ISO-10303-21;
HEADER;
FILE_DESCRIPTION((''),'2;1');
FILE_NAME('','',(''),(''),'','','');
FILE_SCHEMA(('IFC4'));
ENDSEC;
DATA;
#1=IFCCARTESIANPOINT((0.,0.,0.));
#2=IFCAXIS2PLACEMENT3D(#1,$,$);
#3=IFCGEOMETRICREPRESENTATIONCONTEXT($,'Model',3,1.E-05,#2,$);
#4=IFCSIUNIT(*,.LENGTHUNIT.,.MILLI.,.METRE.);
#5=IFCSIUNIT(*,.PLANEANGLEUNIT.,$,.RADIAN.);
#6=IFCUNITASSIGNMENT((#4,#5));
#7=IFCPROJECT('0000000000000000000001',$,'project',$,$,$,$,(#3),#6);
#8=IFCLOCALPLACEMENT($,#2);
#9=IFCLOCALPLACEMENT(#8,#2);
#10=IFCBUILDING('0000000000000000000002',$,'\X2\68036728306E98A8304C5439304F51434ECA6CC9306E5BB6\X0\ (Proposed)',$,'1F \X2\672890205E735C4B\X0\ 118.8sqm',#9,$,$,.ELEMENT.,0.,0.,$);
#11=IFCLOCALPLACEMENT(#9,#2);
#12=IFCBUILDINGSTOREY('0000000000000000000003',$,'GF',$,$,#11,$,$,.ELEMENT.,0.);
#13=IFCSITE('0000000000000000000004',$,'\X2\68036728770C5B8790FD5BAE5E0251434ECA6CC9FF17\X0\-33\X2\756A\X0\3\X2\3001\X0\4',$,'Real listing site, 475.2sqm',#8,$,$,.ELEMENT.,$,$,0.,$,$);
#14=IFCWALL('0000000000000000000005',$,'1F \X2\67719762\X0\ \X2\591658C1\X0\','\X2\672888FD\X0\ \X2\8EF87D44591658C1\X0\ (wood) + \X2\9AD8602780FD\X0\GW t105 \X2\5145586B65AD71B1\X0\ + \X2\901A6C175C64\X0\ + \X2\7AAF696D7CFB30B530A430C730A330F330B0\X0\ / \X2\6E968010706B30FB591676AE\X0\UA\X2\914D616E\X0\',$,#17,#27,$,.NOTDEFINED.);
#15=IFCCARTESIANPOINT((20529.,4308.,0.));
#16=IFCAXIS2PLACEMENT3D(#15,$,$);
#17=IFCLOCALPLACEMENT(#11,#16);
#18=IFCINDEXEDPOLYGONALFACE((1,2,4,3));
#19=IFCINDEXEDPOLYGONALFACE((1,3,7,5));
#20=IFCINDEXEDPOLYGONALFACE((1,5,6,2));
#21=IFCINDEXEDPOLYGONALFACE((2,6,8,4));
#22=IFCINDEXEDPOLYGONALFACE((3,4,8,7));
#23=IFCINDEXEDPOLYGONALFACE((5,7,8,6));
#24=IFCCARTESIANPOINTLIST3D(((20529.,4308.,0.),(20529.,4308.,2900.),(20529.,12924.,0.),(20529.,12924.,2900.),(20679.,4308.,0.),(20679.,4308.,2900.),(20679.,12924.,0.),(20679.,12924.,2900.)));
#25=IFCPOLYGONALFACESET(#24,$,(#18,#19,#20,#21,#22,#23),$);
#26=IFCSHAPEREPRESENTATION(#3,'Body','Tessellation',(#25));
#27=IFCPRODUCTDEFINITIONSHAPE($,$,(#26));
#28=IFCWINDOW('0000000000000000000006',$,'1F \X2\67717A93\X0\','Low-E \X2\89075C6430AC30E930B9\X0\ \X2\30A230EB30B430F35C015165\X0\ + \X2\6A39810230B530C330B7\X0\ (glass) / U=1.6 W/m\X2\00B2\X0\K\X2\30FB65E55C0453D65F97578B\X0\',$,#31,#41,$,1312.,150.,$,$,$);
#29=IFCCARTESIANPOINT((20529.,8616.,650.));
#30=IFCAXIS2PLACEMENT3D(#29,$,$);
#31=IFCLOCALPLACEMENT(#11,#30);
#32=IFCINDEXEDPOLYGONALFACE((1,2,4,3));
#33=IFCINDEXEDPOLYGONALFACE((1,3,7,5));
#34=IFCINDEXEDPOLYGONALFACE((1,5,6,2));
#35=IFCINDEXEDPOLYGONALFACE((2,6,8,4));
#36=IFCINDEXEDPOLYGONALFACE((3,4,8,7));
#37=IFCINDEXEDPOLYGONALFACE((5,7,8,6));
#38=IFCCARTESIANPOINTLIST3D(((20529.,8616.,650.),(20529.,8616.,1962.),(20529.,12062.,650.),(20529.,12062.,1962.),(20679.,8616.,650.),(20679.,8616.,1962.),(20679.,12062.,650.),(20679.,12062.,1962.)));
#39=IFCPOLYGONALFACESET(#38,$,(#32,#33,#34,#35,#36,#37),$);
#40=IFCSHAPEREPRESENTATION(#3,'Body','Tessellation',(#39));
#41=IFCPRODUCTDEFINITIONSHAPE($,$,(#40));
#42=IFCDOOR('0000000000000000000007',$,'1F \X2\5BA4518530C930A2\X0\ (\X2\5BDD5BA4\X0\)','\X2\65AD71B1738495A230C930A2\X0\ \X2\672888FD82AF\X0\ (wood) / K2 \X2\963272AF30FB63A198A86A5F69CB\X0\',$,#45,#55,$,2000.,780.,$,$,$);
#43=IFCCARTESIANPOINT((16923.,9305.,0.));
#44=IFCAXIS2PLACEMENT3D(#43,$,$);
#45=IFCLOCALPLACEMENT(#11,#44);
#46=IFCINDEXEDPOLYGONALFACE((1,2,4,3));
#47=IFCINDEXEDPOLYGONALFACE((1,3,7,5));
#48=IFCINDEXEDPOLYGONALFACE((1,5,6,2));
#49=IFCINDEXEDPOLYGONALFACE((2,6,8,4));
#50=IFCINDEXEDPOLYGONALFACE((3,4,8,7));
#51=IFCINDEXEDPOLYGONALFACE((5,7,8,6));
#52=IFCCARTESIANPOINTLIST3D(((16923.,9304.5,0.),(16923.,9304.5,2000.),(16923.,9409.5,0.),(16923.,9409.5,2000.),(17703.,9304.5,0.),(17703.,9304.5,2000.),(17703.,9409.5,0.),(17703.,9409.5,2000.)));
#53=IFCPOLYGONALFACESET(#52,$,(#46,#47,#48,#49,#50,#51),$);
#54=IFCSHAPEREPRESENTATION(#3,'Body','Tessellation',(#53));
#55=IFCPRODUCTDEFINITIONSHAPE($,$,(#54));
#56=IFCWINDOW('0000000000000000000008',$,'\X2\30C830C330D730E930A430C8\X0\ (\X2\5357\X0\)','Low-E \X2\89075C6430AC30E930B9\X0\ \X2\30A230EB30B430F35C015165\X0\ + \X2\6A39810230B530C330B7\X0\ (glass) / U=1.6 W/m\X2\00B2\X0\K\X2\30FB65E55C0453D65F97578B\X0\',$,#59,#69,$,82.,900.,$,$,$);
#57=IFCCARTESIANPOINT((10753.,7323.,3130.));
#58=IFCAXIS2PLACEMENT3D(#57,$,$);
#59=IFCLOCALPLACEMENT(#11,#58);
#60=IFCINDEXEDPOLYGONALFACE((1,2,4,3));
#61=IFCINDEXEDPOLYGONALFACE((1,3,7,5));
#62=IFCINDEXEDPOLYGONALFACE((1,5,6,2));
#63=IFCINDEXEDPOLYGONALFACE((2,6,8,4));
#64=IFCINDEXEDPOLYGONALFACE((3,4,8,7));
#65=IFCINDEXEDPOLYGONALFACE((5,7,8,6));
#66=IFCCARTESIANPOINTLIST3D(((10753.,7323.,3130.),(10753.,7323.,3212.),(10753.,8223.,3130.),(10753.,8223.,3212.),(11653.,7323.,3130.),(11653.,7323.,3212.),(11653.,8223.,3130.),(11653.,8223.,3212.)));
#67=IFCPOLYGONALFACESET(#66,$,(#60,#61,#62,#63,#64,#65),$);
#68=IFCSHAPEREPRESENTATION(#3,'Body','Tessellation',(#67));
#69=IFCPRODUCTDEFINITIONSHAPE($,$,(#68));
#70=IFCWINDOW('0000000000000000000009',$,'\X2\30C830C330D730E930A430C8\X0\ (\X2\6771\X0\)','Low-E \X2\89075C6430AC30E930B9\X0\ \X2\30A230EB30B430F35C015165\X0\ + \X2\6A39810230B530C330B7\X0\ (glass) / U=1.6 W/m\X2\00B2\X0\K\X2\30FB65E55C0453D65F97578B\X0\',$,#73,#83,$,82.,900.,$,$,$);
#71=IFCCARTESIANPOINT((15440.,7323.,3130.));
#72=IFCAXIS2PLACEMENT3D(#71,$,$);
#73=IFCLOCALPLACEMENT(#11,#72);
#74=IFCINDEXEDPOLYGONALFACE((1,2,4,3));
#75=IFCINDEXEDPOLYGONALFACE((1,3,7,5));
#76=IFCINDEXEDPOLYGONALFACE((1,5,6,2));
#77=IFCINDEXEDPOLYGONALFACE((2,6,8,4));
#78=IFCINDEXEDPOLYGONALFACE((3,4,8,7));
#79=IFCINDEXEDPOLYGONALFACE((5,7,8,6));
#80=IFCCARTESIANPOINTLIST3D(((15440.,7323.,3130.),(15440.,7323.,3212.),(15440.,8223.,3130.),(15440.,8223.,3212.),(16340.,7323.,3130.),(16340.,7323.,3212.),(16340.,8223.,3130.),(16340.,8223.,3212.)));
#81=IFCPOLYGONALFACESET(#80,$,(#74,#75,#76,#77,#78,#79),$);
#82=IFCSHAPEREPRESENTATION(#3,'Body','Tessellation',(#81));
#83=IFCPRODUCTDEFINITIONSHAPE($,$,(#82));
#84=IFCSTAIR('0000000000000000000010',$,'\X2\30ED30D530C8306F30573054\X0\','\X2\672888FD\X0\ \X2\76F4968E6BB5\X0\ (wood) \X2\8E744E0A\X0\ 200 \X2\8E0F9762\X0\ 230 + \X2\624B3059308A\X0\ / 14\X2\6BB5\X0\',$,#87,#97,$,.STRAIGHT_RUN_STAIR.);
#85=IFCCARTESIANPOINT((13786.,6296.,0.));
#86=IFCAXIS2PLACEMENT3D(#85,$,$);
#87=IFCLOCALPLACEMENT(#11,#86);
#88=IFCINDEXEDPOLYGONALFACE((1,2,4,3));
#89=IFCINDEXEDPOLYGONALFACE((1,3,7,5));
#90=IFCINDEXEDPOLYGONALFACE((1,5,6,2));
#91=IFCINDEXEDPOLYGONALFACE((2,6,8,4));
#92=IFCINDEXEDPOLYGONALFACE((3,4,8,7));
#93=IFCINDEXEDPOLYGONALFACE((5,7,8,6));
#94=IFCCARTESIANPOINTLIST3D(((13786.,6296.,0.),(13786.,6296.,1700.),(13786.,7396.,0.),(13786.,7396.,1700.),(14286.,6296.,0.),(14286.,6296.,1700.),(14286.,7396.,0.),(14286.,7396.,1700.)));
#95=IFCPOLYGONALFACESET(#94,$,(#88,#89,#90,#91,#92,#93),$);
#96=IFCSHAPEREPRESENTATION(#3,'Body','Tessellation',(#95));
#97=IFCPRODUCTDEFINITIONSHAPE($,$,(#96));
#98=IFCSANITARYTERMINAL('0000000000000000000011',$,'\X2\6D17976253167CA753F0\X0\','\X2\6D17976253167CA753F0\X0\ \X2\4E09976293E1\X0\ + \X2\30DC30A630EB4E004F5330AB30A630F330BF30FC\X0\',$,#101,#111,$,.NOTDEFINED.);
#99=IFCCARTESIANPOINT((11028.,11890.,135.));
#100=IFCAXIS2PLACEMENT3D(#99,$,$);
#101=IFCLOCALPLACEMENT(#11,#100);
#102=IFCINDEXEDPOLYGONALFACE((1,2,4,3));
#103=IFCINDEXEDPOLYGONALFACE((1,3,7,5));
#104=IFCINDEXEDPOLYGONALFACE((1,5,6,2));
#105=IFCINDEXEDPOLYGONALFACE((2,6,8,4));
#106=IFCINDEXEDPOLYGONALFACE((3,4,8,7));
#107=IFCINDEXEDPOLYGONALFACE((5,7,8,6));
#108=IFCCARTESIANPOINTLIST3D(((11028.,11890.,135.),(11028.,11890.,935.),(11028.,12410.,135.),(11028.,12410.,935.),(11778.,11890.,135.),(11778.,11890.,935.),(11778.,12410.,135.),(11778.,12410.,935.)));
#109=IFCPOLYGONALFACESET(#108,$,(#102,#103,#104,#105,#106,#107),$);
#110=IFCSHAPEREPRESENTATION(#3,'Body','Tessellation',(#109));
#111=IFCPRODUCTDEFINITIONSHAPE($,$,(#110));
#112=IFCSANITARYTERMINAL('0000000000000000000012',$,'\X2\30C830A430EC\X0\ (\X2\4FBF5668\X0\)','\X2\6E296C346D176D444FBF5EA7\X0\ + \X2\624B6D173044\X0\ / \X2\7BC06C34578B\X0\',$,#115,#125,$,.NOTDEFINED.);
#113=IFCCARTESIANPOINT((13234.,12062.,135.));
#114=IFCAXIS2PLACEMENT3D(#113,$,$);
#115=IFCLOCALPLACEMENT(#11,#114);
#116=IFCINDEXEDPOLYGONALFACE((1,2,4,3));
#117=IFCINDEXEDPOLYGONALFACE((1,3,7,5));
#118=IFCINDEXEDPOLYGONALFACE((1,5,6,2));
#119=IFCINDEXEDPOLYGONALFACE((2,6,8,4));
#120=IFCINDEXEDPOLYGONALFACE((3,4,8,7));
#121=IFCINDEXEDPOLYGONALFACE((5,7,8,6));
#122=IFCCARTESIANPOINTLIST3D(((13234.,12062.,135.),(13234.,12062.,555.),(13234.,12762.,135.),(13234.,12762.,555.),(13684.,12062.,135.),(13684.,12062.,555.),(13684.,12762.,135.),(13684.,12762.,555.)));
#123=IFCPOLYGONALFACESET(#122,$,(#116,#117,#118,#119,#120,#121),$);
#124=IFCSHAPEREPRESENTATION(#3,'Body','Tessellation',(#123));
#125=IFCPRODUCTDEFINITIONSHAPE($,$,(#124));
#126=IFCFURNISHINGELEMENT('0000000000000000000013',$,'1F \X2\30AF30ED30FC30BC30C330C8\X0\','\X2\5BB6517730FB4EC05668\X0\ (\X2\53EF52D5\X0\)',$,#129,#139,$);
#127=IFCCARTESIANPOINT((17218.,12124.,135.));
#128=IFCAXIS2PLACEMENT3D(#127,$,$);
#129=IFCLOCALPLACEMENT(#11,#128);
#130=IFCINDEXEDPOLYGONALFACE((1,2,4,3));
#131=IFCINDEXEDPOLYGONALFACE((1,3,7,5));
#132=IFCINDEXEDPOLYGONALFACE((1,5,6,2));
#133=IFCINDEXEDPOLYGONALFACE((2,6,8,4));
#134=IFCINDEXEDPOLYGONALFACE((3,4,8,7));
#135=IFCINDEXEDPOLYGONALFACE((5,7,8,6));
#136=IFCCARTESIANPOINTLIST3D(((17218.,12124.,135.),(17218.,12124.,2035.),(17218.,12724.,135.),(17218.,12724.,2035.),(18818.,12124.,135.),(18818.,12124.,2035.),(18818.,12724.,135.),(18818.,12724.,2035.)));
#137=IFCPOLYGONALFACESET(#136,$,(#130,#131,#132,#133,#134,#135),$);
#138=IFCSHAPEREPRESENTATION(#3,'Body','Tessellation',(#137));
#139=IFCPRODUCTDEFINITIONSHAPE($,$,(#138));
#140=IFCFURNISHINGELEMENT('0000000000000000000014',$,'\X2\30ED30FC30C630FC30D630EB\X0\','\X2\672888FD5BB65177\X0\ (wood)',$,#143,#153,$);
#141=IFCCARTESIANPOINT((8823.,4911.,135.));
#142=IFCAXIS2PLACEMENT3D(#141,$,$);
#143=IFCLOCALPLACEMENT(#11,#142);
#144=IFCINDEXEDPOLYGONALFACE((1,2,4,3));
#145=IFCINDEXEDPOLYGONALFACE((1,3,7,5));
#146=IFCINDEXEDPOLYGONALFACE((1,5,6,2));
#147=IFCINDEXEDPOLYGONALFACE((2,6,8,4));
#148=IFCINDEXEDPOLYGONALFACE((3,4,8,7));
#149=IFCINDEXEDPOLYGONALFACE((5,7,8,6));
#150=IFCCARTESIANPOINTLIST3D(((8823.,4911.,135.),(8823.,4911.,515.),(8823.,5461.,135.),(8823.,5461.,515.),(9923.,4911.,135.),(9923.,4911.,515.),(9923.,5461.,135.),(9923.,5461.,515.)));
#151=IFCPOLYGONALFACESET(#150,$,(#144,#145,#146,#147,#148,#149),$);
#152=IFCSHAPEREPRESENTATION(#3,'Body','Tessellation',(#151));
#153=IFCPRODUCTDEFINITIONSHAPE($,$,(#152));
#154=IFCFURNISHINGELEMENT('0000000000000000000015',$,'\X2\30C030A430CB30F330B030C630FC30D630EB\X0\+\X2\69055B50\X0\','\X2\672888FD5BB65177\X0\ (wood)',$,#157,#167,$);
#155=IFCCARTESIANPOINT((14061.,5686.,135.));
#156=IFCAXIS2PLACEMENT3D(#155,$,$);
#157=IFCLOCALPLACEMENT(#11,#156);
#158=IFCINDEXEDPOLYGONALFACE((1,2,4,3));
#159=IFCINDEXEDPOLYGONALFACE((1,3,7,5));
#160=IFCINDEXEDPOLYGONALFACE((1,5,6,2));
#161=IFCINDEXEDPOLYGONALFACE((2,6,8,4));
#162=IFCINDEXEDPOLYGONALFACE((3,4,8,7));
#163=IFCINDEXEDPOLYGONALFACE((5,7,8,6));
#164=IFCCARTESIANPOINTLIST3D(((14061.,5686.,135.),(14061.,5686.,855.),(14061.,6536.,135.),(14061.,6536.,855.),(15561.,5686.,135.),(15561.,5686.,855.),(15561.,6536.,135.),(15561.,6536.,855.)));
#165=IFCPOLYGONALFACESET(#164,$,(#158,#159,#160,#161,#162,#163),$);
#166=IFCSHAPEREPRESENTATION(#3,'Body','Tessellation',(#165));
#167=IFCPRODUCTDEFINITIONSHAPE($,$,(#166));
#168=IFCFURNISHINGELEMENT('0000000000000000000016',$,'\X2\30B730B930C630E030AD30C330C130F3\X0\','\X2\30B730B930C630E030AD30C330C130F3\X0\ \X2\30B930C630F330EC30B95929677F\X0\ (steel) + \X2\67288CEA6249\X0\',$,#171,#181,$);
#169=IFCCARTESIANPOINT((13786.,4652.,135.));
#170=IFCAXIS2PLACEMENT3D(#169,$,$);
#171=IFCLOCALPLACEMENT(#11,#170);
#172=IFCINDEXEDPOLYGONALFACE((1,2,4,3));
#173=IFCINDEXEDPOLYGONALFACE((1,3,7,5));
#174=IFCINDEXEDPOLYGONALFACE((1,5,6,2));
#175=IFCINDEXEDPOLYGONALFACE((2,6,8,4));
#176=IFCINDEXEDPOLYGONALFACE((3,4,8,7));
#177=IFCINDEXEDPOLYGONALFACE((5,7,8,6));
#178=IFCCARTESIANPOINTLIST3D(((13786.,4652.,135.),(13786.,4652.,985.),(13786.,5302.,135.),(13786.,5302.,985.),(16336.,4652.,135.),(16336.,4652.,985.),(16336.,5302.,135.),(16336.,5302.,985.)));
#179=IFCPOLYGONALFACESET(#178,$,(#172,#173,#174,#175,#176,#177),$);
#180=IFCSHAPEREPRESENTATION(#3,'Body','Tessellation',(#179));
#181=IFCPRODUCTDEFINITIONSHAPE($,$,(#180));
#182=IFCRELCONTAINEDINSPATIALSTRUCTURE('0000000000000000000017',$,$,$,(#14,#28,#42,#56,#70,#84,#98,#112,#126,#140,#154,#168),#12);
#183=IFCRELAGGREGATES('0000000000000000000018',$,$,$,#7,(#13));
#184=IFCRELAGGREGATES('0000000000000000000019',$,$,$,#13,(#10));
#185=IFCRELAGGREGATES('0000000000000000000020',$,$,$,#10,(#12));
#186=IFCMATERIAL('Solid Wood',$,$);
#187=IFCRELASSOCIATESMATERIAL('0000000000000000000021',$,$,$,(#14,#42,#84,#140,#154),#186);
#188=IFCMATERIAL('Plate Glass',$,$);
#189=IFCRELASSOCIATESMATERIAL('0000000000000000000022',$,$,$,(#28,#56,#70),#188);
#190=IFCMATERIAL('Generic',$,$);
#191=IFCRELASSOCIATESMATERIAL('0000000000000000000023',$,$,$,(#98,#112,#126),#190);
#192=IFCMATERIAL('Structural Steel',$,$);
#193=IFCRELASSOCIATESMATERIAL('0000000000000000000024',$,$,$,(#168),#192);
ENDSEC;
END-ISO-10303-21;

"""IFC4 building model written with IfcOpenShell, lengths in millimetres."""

from ifc_helpers import new_model, si_unit, frame, frame_2d, origin, place, context, project, spatial, rectangle, extrude, material, element, fill, save


model = new_model("IFC4")

# Units and contexts
model_context = context("Model", 3, precision=1e-05, world=origin())
ifc_project = project(units=[si_unit("LENGTHUNIT", "METRE", prefix="MILLI"), si_unit("PLANEANGLEUNIT", "RADIAN")], contexts=[model_context])

# Site, building, storey
site_placement = place(None, origin())
site = spatial("IfcSite", under=ifc_project, at=site_placement, Name="栃木県宇都宮市元今泉７-33番3、4", ObjectType="Real listing site, 475.2sqm", CompositionType="ELEMENT", RefElevation=0.0)
building_placement = place(site_placement, origin())
building = spatial("IfcBuilding", under=site, at=building_placement, Name="栃木の風が吹く元今泉の家 (Proposed)", ObjectType="1F 木造平屋 118.8sqm", CompositionType="ELEMENT", ElevationOfRefHeight=0.0, ElevationOfTerrain=0.0)
storey_placement = place(building_placement, origin())
storey = spatial("IfcBuildingStorey", under=building, at=storey_placement, Name="GF", CompositionType="ELEMENT", Elevation=0.0)

# Wall, opening, window
ifc_material_1 = material(Name="Solid Wood")
wall_1_placement = place(storey_placement, frame((20529.0, 4308.0, 0.0)))
wall_1 = element("IfcWall", 1, at=wall_1_placement, inside=storey, material=ifc_material_1, Name="1F 東面 外壁", Description="木製 軸組外壁 (wood) + 高性能GW t105 充填断熱 + 通気層 + 窯業系サイディング / 準耐火・外皮UA配慮", PredefinedType="NOTDEFINED", context=model_context, shape_type="SweptSolid", body=[
    extrude(rectangle(XDim=150.0, YDim=8616.0, at=frame_2d((75.0, 4308.0))), frame((20529.0, 4308.0, 0.0)), (0.0, 0.0, 1.0), 2900.0),
])
opening_placement = place(storey_placement, frame((20529.0, 8616.0, 650.0)))
opening = element("IfcOpeningElement", 2, at=opening_placement, cuts=wall_1, PredefinedType="NOTDEFINED", context=model_context, shape_type="SweptSolid", body=[
    extrude(rectangle(XDim=150.0, YDim=3446.0, at=frame_2d((75.0, 1723.0))), frame((20529.0, 8616.0, 650.0)), (0.0, 0.0, 1.0), 1312.0),
])
ifc_material_2 = material(Name="Plate Glass")
window_1_placement = place(storey_placement, frame((20529.0, 8616.0, 650.0)))
window_1 = element("IfcWindow", 3, at=window_1_placement, inside=storey, material=ifc_material_2, Name="1F 東窓", Description="Low-E 複層ガラス アルゴン封入 + 樹脂サッシ (glass) / U=1.6 W/m²K・日射取得型", OverallHeight=1312.0, OverallWidth=150.0, context=model_context, shape_type="SweptSolid", body=[
    extrude(rectangle(XDim=150.0, YDim=3446.0, at=frame_2d((75.0, 1723.0))), frame((20529.0, 8616.0, 650.0)), (0.0, 0.0, 1.0), 1312.0),
])
fill(opening, window_1)

# Door
door_placement = place(storey_placement, frame((16923.0, 9305.0, 0.0)))
element("IfcDoor", 4, at=door_placement, inside=storey, material=ifc_material_1, Name="1F 室内ドア (寝室)", Description="断熱玄関ドア 木製芯 (wood) / K2 防犯・採風機構", OverallHeight=2000.0, OverallWidth=780.0, context=model_context, shape_type="SweptSolid", body=[
    extrude(rectangle(XDim=780.0, YDim=105.0, at=frame_2d((390.0, 52.0))), frame((16923.0, 9305.0, 0.0)), (0.0, 0.0, 1.0), 2000.0),
])

# Windows
window_2_placement = place(storey_placement, frame((10753.0, 7323.0, 3130.0)))
element("IfcWindow", 5, at=window_2_placement, inside=storey, material=ifc_material_2, Name="トップライト (南)", Description="Low-E 複層ガラス アルゴン封入 + 樹脂サッシ (glass) / U=1.6 W/m²K・日射取得型", OverallHeight=82.0, OverallWidth=900.0, context=model_context, shape_type="SweptSolid", body=[
    extrude(rectangle(XDim=900.0, YDim=900.0, at=frame_2d((450.0, 450.0))), frame((10753.0, 7323.0, 3130.0)), (0.0, 0.0, 1.0), 82.0),
])
window_3_placement = place(storey_placement, frame((15440.0, 7323.0, 3130.0)))
element("IfcWindow", 6, at=window_3_placement, inside=storey, material=ifc_material_2, Name="トップライト (東)", Description="Low-E 複層ガラス アルゴン封入 + 樹脂サッシ (glass) / U=1.6 W/m²K・日射取得型", OverallHeight=82.0, OverallWidth=900.0, context=model_context, shape_type="SweptSolid", body=[
    extrude(rectangle(XDim=900.0, YDim=900.0, at=frame_2d((450.0, 450.0))), frame((15440.0, 7323.0, 3130.0)), (0.0, 0.0, 1.0), 82.0),
])

# Stair
stair_placement = place(storey_placement, frame((13786.0, 6296.0, 0.0)))
element("IfcStair", 7, at=stair_placement, inside=storey, material=ifc_material_1, Name="ロフトはしご", Description="木製 直階段 (wood) 蹴上 200 踏面 230 + 手すり / 14段", PredefinedType="STRAIGHT_RUN_STAIR", context=model_context, shape_type="SweptSolid", body=[
    extrude(rectangle(XDim=500.0, YDim=1100.0, at=frame_2d((250.0, 550.0))), frame((13786.0, 6296.0, 0.0)), (0.0, 0.0, 1.0), 1700.0),
])

# Sanitary terminals
ifc_material_3 = material(Name="Generic")
sanitary_terminal_1_placement = place(storey_placement, frame((11028.0, 11890.0, 135.0)))
element("IfcSanitaryTerminal", 8, at=sanitary_terminal_1_placement, inside=storey, material=ifc_material_3, Name="洗面化粧台", Description="洗面化粧台 三面鏡 + ボウル一体カウンター", PredefinedType="NOTDEFINED", context=model_context, shape_type="SweptSolid", body=[
    extrude(rectangle(XDim=750.0, YDim=520.0, at=frame_2d((375.0, 260.0))), frame((11028.0, 11890.0, 135.0)), (0.0, 0.0, 1.0), 800.0),
])
sanitary_terminal_2_placement = place(storey_placement, frame((13234.0, 12062.0, 135.0)))
element("IfcSanitaryTerminal", 9, at=sanitary_terminal_2_placement, inside=storey, material=ifc_material_3, Name="トイレ (便器)", Description="温水洗浄便座 + 手洗い / 節水型", PredefinedType="NOTDEFINED", context=model_context, shape_type="SweptSolid", body=[
    extrude(rectangle(XDim=450.0, YDim=700.0, at=frame_2d((225.0, 350.0))), frame((13234.0, 12062.0, 135.0)), (0.0, 0.0, 1.0), 420.0),
])

# Furnishing elements
furnishing_1_placement = place(storey_placement, frame((17218.0, 12124.0, 135.0)))
element("IfcFurnishingElement", 10, at=furnishing_1_placement, inside=storey, material=ifc_material_3, Name="1F クローゼット", Description="家具・什器 (可動)", context=model_context, shape_type="SweptSolid", body=[
    extrude(rectangle(XDim=1600.0, YDim=600.0, at=frame_2d((800.0, 300.0))), frame((17218.0, 12124.0, 135.0)), (0.0, 0.0, 1.0), 1900.0),
])
furnishing_2_placement = place(storey_placement, frame((8823.0, 4911.0, 135.0)))
element("IfcFurnishingElement", 11, at=furnishing_2_placement, inside=storey, material=ifc_material_1, Name="ローテーブル", Description="木製家具 (wood)", context=model_context, shape_type="SweptSolid", body=[
    extrude(rectangle(XDim=1100.0, YDim=550.0, at=frame_2d((550.0, 275.0))), frame((8823.0, 4911.0, 135.0)), (0.0, 0.0, 1.0), 380.0),
])
furnishing_3_placement = place(storey_placement, frame((14061.0, 5686.0, 135.0)))
element("IfcFurnishingElement", 12, at=furnishing_3_placement, inside=storey, material=ifc_material_1, Name="ダイニングテーブル+椅子", Description="木製家具 (wood)", context=model_context, shape_type="SweptSolid", body=[
    extrude(rectangle(XDim=1500.0, YDim=850.0, at=frame_2d((750.0, 425.0))), frame((14061.0, 5686.0, 135.0)), (0.0, 0.0, 1.0), 720.0),
])
ifc_material_4 = material(Name="Structural Steel")
furnishing_4_placement = place(storey_placement, frame((13786.0, 4652.0, 135.0)))
element("IfcFurnishingElement", 13, at=furnishing_4_placement, inside=storey, material=ifc_material_4, Name="システムキッチン", Description="システムキッチン ステンレス天板 (steel) + 木質扉", context=model_context, shape_type="SweptSolid", body=[
    extrude(rectangle(XDim=2550.0, YDim=650.0, at=frame_2d((1275.0, 325.0))), frame((13786.0, 4652.0, 135.0)), (0.0, 0.0, 1.0), 850.0),
])

save(model, "model.ifc")
